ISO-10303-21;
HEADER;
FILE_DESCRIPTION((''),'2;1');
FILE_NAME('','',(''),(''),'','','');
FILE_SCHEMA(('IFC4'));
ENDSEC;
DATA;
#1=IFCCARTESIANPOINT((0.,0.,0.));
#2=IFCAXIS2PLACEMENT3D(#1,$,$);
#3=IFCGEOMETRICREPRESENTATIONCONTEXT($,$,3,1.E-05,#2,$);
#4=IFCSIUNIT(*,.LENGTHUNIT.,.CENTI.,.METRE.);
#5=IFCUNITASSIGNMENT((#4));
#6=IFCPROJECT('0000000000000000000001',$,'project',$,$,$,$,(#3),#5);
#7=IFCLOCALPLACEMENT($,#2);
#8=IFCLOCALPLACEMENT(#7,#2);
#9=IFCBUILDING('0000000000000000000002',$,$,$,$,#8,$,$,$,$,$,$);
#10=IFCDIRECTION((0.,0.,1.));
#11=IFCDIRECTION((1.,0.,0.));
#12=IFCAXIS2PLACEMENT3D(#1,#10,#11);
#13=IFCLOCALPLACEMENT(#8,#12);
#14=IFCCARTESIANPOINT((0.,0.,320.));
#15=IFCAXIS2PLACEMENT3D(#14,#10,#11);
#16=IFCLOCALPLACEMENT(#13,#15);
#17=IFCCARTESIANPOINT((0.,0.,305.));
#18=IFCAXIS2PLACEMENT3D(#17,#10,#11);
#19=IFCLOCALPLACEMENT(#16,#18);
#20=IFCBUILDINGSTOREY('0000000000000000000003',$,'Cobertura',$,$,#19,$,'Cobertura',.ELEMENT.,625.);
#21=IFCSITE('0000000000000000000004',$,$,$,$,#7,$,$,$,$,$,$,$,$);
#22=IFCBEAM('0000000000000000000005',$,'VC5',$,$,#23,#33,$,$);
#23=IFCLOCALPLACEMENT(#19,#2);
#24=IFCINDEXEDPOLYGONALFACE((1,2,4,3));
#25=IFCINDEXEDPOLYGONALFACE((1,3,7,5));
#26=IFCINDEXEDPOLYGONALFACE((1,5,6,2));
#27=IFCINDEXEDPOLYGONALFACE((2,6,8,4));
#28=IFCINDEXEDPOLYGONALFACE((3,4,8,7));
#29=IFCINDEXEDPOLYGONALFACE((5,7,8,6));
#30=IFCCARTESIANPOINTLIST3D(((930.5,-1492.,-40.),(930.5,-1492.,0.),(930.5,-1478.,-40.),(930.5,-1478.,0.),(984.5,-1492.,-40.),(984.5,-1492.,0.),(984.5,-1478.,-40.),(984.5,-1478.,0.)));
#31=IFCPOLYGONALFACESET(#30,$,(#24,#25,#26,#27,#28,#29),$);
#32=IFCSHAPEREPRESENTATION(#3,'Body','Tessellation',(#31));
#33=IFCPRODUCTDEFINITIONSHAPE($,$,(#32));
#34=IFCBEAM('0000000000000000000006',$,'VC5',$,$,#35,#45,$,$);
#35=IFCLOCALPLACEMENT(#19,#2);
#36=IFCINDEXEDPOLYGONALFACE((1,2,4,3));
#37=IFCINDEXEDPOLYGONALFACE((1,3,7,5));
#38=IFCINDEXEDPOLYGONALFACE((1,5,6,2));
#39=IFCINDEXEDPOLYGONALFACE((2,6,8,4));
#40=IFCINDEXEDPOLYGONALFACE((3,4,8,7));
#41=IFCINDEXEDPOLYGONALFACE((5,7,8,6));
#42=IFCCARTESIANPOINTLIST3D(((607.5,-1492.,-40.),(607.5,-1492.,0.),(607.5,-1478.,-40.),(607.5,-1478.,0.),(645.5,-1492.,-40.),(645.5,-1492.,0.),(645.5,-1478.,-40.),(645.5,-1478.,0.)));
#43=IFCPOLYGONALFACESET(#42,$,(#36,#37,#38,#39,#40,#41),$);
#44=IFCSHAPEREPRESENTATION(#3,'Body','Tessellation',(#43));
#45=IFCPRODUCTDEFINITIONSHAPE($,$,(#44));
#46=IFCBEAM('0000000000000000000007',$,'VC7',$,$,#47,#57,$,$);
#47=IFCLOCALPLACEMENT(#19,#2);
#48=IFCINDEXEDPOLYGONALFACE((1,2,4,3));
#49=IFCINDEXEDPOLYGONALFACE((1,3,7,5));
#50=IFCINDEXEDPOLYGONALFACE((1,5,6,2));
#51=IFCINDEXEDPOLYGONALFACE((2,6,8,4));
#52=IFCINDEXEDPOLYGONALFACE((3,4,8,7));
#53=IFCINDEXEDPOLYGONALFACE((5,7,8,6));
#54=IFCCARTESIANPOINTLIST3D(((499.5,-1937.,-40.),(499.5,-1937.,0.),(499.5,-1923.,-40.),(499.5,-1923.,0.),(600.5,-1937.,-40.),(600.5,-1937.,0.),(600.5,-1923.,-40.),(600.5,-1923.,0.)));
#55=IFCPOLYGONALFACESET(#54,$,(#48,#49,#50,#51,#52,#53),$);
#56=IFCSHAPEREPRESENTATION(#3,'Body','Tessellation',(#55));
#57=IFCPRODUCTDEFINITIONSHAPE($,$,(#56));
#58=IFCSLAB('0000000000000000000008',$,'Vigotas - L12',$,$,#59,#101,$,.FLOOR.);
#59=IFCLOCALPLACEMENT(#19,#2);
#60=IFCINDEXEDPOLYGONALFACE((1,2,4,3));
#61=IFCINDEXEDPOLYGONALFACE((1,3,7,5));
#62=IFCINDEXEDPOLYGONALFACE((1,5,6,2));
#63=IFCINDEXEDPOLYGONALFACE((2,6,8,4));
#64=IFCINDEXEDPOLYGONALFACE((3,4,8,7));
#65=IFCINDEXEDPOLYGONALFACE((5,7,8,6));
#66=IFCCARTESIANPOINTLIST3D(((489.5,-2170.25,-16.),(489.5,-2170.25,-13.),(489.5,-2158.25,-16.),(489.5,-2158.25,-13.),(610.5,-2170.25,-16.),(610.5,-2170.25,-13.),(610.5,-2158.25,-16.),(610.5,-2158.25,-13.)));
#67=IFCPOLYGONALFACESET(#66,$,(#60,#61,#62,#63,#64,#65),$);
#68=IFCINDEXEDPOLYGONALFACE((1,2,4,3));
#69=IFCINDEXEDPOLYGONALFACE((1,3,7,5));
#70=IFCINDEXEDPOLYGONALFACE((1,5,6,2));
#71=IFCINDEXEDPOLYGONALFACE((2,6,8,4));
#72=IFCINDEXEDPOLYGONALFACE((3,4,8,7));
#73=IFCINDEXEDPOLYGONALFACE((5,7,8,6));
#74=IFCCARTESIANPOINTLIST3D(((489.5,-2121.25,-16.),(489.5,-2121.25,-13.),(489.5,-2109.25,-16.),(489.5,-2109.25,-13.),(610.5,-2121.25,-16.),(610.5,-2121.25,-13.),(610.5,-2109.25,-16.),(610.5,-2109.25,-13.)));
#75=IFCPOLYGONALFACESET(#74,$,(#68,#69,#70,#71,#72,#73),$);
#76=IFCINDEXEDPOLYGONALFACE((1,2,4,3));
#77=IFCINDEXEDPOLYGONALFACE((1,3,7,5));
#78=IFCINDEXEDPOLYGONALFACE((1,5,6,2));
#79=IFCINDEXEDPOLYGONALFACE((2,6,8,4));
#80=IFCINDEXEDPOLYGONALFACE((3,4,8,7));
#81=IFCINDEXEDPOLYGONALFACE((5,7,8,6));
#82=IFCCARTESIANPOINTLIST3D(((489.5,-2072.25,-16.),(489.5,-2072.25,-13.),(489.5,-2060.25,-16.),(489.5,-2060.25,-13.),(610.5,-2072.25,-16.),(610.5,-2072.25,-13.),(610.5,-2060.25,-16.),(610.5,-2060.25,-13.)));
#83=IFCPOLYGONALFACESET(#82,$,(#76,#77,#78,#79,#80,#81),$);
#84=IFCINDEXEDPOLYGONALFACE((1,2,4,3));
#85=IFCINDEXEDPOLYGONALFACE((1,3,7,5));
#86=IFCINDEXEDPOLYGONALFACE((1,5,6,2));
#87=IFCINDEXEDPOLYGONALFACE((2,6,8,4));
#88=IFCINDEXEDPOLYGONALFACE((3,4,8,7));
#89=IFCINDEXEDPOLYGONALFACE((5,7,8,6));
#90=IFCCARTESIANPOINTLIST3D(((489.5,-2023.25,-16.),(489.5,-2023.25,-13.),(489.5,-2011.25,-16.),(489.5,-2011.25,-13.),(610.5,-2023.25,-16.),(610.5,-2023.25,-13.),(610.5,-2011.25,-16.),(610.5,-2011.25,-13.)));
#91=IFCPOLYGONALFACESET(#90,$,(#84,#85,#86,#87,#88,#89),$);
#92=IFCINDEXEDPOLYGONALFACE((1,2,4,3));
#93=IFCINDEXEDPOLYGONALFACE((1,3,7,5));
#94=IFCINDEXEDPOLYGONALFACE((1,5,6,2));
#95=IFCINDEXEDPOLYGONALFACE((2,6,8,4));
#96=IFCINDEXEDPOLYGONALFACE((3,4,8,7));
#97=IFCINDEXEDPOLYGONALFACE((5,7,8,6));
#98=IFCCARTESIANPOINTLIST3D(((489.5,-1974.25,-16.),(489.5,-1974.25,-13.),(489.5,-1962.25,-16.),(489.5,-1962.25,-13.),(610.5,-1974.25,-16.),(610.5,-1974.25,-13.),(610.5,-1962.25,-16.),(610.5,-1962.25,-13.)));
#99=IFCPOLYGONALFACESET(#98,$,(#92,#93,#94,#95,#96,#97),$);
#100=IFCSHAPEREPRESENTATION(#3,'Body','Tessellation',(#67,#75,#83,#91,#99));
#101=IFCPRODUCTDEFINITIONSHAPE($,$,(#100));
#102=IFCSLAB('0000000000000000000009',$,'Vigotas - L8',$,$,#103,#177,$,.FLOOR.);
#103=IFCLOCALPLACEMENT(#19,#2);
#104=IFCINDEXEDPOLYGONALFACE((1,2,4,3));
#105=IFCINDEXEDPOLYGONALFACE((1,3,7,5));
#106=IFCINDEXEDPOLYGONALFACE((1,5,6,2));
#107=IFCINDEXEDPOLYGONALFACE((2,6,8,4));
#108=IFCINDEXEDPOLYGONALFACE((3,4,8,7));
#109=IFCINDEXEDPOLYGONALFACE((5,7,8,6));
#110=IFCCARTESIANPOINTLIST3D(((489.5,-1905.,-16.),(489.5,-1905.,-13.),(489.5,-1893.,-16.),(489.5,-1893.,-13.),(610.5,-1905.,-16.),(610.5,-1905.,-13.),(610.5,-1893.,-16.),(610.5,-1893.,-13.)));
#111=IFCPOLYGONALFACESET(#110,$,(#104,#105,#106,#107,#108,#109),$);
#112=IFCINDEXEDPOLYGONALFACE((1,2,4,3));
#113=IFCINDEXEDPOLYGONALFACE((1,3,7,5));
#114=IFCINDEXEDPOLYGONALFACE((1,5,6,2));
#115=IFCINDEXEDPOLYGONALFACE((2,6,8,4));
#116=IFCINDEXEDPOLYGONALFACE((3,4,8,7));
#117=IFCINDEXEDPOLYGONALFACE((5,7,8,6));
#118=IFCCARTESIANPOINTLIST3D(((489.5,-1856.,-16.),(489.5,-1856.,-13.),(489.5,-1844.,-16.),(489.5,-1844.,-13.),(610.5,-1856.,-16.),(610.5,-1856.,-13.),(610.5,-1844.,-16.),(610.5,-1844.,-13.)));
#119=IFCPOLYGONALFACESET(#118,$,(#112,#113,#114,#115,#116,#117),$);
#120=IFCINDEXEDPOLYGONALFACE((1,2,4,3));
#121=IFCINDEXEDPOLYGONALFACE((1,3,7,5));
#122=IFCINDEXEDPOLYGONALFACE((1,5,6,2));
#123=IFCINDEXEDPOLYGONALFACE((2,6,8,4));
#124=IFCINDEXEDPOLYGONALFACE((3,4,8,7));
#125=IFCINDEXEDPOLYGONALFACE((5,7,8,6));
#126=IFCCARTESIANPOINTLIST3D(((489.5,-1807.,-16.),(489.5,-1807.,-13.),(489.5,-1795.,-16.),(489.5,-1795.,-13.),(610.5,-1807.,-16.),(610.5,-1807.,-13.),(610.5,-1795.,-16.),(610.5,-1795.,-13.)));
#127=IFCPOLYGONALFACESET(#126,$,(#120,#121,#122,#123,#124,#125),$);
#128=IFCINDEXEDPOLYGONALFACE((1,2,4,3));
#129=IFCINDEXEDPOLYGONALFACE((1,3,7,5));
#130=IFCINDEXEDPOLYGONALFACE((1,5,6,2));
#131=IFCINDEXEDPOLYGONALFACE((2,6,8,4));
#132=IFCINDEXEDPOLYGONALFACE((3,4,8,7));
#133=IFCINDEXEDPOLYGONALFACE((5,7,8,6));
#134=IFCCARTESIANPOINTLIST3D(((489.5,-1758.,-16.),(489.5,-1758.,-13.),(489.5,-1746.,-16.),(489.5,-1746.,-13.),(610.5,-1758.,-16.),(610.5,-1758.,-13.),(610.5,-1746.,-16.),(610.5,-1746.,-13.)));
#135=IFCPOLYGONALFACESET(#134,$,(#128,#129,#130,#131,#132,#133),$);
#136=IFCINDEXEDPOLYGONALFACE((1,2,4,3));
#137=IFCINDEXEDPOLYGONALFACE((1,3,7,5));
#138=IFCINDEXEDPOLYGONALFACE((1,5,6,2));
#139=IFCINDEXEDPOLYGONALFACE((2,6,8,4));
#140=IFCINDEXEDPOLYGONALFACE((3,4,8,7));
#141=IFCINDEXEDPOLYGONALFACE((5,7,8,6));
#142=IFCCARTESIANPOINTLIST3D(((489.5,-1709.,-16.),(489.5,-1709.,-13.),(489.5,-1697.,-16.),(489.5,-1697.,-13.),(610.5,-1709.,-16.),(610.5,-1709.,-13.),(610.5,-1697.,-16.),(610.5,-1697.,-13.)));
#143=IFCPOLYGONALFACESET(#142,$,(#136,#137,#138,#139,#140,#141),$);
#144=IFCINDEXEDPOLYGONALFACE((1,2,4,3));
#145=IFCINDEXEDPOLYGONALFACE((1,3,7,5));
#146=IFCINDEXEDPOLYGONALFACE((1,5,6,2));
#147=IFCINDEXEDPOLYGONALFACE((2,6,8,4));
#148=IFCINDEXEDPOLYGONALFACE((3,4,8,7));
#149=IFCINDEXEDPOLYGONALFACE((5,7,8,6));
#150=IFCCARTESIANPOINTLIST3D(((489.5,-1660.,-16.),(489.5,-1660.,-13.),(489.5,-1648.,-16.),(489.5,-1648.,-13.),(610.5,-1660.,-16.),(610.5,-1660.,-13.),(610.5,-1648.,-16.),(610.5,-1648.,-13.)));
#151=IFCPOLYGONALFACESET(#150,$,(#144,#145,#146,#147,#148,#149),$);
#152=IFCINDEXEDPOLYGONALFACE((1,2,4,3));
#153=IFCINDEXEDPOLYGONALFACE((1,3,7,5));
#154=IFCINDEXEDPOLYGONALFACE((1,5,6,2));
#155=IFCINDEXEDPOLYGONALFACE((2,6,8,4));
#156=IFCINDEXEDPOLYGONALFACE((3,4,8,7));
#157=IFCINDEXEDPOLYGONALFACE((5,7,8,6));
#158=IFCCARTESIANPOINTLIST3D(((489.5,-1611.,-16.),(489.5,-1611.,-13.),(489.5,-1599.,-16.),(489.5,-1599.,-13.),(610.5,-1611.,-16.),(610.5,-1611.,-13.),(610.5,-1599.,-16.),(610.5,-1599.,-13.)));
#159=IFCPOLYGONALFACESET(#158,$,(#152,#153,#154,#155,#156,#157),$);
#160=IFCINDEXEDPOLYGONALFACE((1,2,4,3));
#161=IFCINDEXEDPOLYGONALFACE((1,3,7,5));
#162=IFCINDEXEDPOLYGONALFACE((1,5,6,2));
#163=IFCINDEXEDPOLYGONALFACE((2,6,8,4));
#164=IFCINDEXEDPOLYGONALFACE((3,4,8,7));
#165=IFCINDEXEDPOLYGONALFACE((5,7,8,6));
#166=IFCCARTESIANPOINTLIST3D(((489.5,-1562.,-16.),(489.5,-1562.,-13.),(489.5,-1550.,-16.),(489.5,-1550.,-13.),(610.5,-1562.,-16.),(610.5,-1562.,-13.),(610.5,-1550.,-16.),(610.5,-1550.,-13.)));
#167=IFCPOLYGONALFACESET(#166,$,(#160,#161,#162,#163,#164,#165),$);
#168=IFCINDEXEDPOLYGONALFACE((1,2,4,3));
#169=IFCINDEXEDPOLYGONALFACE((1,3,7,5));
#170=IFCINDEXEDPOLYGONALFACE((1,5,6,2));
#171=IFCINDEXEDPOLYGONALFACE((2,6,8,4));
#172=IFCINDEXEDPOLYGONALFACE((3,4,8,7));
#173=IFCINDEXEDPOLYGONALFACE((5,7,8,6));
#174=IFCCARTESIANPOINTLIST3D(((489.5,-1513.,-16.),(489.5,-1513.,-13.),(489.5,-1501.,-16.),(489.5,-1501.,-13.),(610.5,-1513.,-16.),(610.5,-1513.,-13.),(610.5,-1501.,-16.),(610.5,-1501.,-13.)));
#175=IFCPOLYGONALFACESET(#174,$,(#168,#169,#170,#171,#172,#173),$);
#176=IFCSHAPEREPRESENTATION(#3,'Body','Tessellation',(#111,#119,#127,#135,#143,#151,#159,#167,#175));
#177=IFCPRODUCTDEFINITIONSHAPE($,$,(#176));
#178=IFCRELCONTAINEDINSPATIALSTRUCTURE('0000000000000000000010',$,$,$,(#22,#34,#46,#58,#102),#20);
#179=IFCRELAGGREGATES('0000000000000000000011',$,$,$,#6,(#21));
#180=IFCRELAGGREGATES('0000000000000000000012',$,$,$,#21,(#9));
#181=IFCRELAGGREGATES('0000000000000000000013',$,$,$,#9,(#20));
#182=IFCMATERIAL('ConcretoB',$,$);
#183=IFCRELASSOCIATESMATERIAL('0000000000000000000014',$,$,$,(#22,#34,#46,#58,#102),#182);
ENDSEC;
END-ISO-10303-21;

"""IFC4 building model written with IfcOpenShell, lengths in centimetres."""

from ifc_helpers import new_model, si_unit, frame, origin, origin_with_axes, place, context, project, spatial, polyline, outline, extrude, material, element, save


model = new_model("IFC4")

# Units and contexts
context_of_model = context(None, 3, precision=1e-05, world=origin())
ifc_project = project(units=[si_unit("LENGTHUNIT", "METRE", prefix="CENTI")], contexts=[context_of_model])

# Site, building, storey
site_placement = place(None, origin())
site = spatial("IfcSite", under=ifc_project, at=site_placement)
building_placement = place(site_placement, origin())
building = spatial("IfcBuilding", under=site, at=building_placement)
placement_1 = place(building_placement, origin_with_axes())
placement_2 = place(placement_1, frame((0.0, 0.0, 320.0), z_axis=(0.0, 0.0, 1.0), x_axis=(1.0, 0.0, 0.0)))
storey_placement = place(placement_2, frame((0.0, 0.0, 305.0), z_axis=(0.0, 0.0, 1.0), x_axis=(1.0, 0.0, 0.0)))
storey = spatial("IfcBuildingStorey", under=building, at=storey_placement, Name="Cobertura", LongName="Cobertura", CompositionType="ELEMENT", Elevation=625.0)

# Shared definitions
ifc_material_1 = material(Name="ConcretoB")

# Beams
beam_1_placement = place(storey_placement, frame((957.5, -1485.0, 0.0), z_axis=(0.0, 0.0, 1.0), x_axis=(1.0, 0.0, 0.0)))
element("IfcBeam", 1, at=beam_1_placement, inside=storey, material=ifc_material_1, Name="VC5", context=context_of_model, shape_type="SolidModel", body=[
    extrude(outline(polyline([(-7.0, -20.0), (7.0, -20.0), (7.0, 20.0), (-7.0, 20.0), (-7.0, -20.0)])), frame((-27.0, 0.0, -20.0), z_axis=(1.0, 0.0, 0.0), x_axis=(0.0, -1.0, 0.0)), (0.0, 0.0, 1.0), 54.0),
])
beam_2_placement = place(storey_placement, frame((626.5, -1485.0, 0.0), z_axis=(0.0, 0.0, 1.0), x_axis=(1.0, 0.0, 0.0)))
element("IfcBeam", 2, at=beam_2_placement, inside=storey, material=ifc_material_1, Name="VC5", context=context_of_model, shape_type="SolidModel", body=[
    extrude(outline(polyline([(-7.0, -20.0), (7.0, -20.0), (7.0, 20.0), (-7.0, 20.0), (-7.0, -20.0)])), frame((-19.0, 0.0, -20.0), z_axis=(1.0, 0.0, 0.0), x_axis=(0.0, -1.0, 0.0)), (0.0, 0.0, 1.0), 38.0),
])
beam_3_placement = place(storey_placement, frame((550.0, -1930.0, 0.0), z_axis=(0.0, 0.0, 1.0), x_axis=(1.0, 0.0, 0.0)))
element("IfcBeam", 3, at=beam_3_placement, inside=storey, material=ifc_material_1, Name="VC7", context=context_of_model, shape_type="SolidModel", body=[
    extrude(outline(polyline([(-7.0, -20.0), (7.0, -20.0), (7.0, 20.0), (-7.0, 20.0), (-7.0, -20.0)])), frame((-50.5, 0.0, -20.0), z_axis=(1.0, 0.0, 0.0), x_axis=(0.0, -1.0, 0.0)), (0.0, 0.0, 1.0), 101.0),
])

# Slabs
slab_1_placement = place(storey_placement, frame((550.0, -2066.25, -13.0), z_axis=(0.0, 0.0, 1.0), x_axis=(1.0, 0.0, 0.0)))
element("IfcSlab", 4, at=slab_1_placement, inside=storey, material=ifc_material_1, Name="Vigotas - L12", PredefinedType="FLOOR", context=context_of_model, shape_type="SolidModel", body=[
    extrude(outline(polyline([(6.0, 1.5), (-6.0, 1.5), (-6.0, -1.5), (6.0, -1.5), (6.0, 1.5), (6.0, 1.5)])), frame((-60.5, -98.0, -1.5), z_axis=(1.0, 0.0, 0.0), x_axis=(0.0, -1.0, 0.0)), (0.0, 0.0, 1.0), 121.0),
    extrude(outline(polyline([(6.0, 1.5), (-6.0, 1.5), (-6.0, -1.5), (6.0, -1.5), (6.0, 1.5), (6.0, 1.5)])), frame((-60.5, -49.0, -1.5), z_axis=(1.0, 0.0, 0.0), x_axis=(0.0, -1.0, 0.0)), (0.0, 0.0, 1.0), 121.0),
    extrude(outline(polyline([(6.0, 1.5), (-6.0, 1.5), (-6.0, -1.5), (6.0, -1.5), (6.0, 1.5), (6.0, 1.5)])), frame((-60.5, 0.0, -1.5), z_axis=(1.0, 0.0, 0.0), x_axis=(0.0, -1.0, 0.0)), (0.0, 0.0, 1.0), 121.0),
    extrude(outline(polyline([(6.0, 1.5), (-6.0, 1.5), (-6.0, -1.5), (6.0, -1.5), (6.0, 1.5), (6.0, 1.5)])), frame((-60.5, 49.0, -1.5), z_axis=(1.0, 0.0, 0.0), x_axis=(0.0, -1.0, 0.0)), (0.0, 0.0, 1.0), 121.0),
    extrude(outline(polyline([(6.0, 1.5), (-6.0, 1.5), (-6.0, -1.5), (6.0, -1.5), (6.0, 1.5), (6.0, 1.5)])), frame((-60.5, 98.0, -1.5), z_axis=(1.0, 0.0, 0.0), x_axis=(0.0, -1.0, 0.0)), (0.0, 0.0, 1.0), 121.0),
])
slab_2_placement = place(storey_placement, frame((550.0, -1703.0, -13.0), z_axis=(0.0, 0.0, 1.0), x_axis=(1.0, 0.0, 0.0)))
element("IfcSlab", 5, at=slab_2_placement, inside=storey, material=ifc_material_1, Name="Vigotas - L8", PredefinedType="FLOOR", context=context_of_model, shape_type="SolidModel", body=[
    extrude(outline(polyline([(6.0, 1.5), (-6.0, 1.5), (-6.0, -1.5), (6.0, -1.5), (6.0, 1.5), (6.0, 1.5)])), frame((-60.5, -196.0, -1.5), z_axis=(1.0, 0.0, 0.0), x_axis=(0.0, -1.0, 0.0)), (0.0, 0.0, 1.0), 121.0),
    extrude(outline(polyline([(6.0, 1.5), (-6.0, 1.5), (-6.0, -1.5), (6.0, -1.5), (6.0, 1.5), (6.0, 1.5)])), frame((-60.5, -147.0, -1.5), z_axis=(1.0, 0.0, 0.0), x_axis=(0.0, -1.0, 0.0)), (0.0, 0.0, 1.0), 121.0),
    extrude(outline(polyline([(6.0, 1.5), (-6.0, 1.5), (-6.0, -1.5), (6.0, -1.5), (6.0, 1.5), (6.0, 1.5)])), frame((-60.5, -98.0, -1.5), z_axis=(1.0, 0.0, 0.0), x_axis=(0.0, -1.0, 0.0)), (0.0, 0.0, 1.0), 121.0),
    extrude(outline(polyline([(6.0, 1.5), (-6.0, 1.5), (-6.0, -1.5), (6.0, -1.5), (6.0, 1.5), (6.0, 1.5)])), frame((-60.5, -49.0, -1.5), z_axis=(1.0, 0.0, 0.0), x_axis=(0.0, -1.0, 0.0)), (0.0, 0.0, 1.0), 121.0),
    extrude(outline(polyline([(6.0, 1.5), (-6.0, 1.5), (-6.0, -1.5), (6.0, -1.5), (6.0, 1.5), (6.0, 1.5)])), frame((-60.5, 0.0, -1.5), z_axis=(1.0, 0.0, 0.0), x_axis=(0.0, -1.0, 0.0)), (0.0, 0.0, 1.0), 121.0),
    extrude(outline(polyline([(6.0, 1.5), (-6.0, 1.5), (-6.0, -1.5), (6.0, -1.5), (6.0, 1.5), (6.0, 1.5)])), frame((-60.5, 49.0, -1.5), z_axis=(1.0, 0.0, 0.0), x_axis=(0.0, -1.0, 0.0)), (0.0, 0.0, 1.0), 121.0),
    extrude(outline(polyline([(6.0, 1.5), (-6.0, 1.5), (-6.0, -1.5), (6.0, -1.5), (6.0, 1.5), (6.0, 1.5)])), frame((-60.5, 98.0, -1.5), z_axis=(1.0, 0.0, 0.0), x_axis=(0.0, -1.0, 0.0)), (0.0, 0.0, 1.0), 121.0),
    extrude(outline(polyline([(6.0, 1.5), (-6.0, 1.5), (-6.0, -1.5), (6.0, -1.5), (6.0, 1.5), (6.0, 1.5)])), frame((-60.5, 147.0, -1.5), z_axis=(1.0, 0.0, 0.0), x_axis=(0.0, -1.0, 0.0)), (0.0, 0.0, 1.0), 121.0),
    extrude(outline(polyline([(6.0, 1.5), (-6.0, 1.5), (-6.0, -1.5), (6.0, -1.5), (6.0, 1.5), (6.0, 1.5)])), frame((-60.5, 196.0, -1.5), z_axis=(1.0, 0.0, 0.0), x_axis=(0.0, -1.0, 0.0)), (0.0, 0.0, 1.0), 121.0),
])

save(model, "model.ifc")
